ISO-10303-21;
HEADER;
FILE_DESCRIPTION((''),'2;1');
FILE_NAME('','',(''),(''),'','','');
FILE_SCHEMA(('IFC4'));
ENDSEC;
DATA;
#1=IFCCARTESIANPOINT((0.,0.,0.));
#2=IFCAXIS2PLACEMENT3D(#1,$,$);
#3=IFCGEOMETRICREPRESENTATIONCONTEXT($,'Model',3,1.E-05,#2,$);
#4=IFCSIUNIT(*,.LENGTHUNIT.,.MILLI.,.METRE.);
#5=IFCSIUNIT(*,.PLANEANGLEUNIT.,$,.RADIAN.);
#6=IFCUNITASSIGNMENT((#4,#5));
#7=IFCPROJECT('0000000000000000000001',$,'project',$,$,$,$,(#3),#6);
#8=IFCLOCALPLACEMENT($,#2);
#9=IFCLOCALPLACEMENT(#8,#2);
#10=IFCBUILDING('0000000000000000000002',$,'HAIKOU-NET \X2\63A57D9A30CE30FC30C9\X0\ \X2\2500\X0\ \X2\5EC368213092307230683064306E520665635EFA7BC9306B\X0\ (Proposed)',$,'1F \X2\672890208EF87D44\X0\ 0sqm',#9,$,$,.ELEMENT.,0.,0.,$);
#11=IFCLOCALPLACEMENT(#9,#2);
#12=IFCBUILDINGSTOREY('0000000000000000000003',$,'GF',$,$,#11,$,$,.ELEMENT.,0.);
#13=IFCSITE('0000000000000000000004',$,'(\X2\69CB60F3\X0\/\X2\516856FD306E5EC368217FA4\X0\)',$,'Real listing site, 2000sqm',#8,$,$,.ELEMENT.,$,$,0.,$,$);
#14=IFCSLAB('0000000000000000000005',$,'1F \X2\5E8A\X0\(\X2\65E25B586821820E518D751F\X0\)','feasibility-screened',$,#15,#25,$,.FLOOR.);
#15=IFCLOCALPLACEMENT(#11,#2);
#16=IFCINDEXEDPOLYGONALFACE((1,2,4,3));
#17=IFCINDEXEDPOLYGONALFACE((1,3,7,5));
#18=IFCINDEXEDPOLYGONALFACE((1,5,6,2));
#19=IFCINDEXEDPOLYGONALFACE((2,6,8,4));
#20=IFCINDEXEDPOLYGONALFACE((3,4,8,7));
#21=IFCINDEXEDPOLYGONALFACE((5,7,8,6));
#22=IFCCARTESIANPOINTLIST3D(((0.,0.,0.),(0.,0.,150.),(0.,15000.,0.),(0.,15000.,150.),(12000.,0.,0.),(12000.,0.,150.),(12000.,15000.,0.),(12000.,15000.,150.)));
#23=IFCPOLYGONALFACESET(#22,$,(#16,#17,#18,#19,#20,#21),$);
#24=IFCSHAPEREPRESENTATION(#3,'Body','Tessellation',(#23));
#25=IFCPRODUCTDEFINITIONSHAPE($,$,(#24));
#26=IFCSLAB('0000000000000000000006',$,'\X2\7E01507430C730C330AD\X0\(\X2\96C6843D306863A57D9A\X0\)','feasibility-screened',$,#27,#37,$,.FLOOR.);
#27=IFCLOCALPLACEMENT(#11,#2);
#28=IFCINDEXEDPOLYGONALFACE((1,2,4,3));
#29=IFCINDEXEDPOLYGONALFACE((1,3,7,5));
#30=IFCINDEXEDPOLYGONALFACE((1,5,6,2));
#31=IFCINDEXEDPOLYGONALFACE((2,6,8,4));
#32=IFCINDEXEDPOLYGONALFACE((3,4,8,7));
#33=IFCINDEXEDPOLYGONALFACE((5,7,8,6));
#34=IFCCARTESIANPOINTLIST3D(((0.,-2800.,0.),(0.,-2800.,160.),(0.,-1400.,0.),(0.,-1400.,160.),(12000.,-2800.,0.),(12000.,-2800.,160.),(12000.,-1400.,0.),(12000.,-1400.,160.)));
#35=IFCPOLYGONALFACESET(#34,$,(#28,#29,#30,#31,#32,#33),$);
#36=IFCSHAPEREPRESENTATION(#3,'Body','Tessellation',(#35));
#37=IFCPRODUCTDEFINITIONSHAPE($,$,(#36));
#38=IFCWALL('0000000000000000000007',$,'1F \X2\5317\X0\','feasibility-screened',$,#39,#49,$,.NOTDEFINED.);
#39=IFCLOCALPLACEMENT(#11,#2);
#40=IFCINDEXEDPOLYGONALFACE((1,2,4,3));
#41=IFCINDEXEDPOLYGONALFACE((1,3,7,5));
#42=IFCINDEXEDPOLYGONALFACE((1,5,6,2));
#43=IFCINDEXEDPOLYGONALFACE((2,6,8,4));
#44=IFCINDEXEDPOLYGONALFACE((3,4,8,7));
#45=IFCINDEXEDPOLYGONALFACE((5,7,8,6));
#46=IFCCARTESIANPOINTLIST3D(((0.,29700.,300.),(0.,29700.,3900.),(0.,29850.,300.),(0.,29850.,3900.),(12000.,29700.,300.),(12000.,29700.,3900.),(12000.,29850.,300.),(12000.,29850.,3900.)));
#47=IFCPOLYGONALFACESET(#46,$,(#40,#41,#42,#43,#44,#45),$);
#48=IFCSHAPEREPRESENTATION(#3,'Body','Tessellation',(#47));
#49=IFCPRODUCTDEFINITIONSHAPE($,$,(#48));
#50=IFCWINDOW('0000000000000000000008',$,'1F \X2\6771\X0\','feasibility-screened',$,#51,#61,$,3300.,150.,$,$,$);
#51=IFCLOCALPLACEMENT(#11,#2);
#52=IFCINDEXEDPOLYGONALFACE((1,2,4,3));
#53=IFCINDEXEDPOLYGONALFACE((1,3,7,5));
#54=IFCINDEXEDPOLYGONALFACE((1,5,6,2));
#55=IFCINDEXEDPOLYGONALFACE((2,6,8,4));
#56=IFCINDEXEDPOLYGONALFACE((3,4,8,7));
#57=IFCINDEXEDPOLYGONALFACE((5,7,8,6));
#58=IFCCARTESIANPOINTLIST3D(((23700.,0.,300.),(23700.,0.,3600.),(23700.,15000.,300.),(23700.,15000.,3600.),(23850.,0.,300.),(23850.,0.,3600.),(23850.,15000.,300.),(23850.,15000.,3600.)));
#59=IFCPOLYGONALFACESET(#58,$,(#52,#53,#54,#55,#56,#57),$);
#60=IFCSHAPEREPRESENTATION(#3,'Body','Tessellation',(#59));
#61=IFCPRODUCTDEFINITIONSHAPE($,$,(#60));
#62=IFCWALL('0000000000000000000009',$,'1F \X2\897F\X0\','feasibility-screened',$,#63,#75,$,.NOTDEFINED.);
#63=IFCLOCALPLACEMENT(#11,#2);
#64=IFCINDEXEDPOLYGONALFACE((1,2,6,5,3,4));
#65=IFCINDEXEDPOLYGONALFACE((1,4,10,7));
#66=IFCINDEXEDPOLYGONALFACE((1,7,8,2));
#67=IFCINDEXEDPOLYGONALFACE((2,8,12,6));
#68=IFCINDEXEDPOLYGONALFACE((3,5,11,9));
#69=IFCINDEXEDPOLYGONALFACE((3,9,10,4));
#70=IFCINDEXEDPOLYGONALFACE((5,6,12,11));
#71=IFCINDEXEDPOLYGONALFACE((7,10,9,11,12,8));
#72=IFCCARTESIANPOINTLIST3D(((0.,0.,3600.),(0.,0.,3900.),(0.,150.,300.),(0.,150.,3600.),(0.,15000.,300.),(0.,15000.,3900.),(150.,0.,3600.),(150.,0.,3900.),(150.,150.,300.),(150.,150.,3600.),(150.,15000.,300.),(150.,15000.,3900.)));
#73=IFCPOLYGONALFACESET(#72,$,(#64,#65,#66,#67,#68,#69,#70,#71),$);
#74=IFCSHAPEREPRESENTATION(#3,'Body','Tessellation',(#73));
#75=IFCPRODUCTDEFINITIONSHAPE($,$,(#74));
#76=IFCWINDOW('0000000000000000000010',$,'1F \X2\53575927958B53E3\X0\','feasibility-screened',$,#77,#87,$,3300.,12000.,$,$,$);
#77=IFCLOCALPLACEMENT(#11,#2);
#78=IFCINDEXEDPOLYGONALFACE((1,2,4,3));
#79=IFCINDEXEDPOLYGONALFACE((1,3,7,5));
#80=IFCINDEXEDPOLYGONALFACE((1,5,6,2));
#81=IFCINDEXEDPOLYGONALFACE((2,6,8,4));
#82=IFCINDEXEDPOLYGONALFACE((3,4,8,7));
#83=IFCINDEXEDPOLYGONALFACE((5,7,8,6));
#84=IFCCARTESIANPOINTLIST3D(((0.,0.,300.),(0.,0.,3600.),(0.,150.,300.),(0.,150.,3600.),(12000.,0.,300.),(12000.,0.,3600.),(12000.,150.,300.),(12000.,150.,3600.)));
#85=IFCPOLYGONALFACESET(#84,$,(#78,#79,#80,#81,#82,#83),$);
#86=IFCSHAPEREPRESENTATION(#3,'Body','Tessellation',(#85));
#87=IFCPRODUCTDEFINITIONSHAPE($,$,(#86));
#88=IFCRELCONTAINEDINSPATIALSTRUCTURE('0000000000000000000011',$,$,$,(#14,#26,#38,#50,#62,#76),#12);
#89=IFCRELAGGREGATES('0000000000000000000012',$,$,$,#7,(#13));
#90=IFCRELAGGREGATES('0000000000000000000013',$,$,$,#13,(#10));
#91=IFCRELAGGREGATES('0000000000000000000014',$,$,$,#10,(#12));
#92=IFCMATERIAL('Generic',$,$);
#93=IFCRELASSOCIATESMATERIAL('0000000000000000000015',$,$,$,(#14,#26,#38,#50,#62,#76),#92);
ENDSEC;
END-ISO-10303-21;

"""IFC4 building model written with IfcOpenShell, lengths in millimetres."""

from ifc_helpers import new_model, si_unit, frame, frame_2d, origin, place, context, project, spatial, rectangle, extrude, material, element, fill, save


model = new_model("IFC4")

# Units and contexts
model_context = context("Model", 3, precision=1e-05, world=origin())
ifc_project = project(units=[si_unit("LENGTHUNIT", "METRE", prefix="MILLI"), si_unit("PLANEANGLEUNIT", "RADIAN")], contexts=[model_context])

# Site, building, storey
site_placement = place(None, origin())
site = spatial("IfcSite", under=ifc_project, at=site_placement, Name="(構想/全国の廃校群)", ObjectType="Real listing site, 2000sqm", CompositionType="ELEMENT", RefElevation=0.0)
building_placement = place(site_placement, origin())
building = spatial("IfcBuilding", under=site, at=building_placement, Name="HAIKOU-NET 接続ノード ─ 廃校をひとつの分散建築に (Proposed)", ObjectType="1F 木造軸組 0sqm", CompositionType="ELEMENT", ElevationOfRefHeight=0.0, ElevationOfTerrain=0.0)
storey_placement = place(building_placement, origin())
storey = spatial("IfcBuildingStorey", under=building, at=storey_placement, Name="GF", CompositionType="ELEMENT", Elevation=0.0)

# Slabs
ifc_material = material(Name="Generic")
slab_1_placement = place(storey_placement, origin())
element("IfcSlab", 1, at=slab_1_placement, inside=storey, material=ifc_material, Name="1F 床(既存校舎再生)", Description="feasibility-screened", PredefinedType="FLOOR", context=model_context, shape_type="SweptSolid", body=[
    extrude(rectangle(XDim=12000.0, YDim=15000.0, at=frame_2d((6000.0, 7500.0))), origin(), (0.0, 0.0, 1.0), 150.0),
])
slab_2_placement = place(storey_placement, frame((0.0, -1400.0, 0.0)))
element("IfcSlab", 2, at=slab_2_placement, inside=storey, material=ifc_material, Name="縁側デッキ(集落と接続)", Description="feasibility-screened", PredefinedType="FLOOR", context=model_context, shape_type="SweptSolid", body=[
    extrude(rectangle(XDim=12000.0, YDim=1400.0, at=frame_2d((6000.0, 700.0))), frame((0.0, -1400.0, 0.0)), (0.0, 0.0, 1.0), 160.0),
])

# Walls, openings, windows
wall_1_placement = place(storey_placement, frame((0.0, 14850.0, 150.0)))
wall_1 = element("IfcWall", 3, at=wall_1_placement, inside=storey, material=ifc_material, Name="1F 北", Description="feasibility-screened", PredefinedType="NOTDEFINED", context=model_context, shape_type="SweptSolid", body=[
    extrude(rectangle(XDim=12000.0, YDim=150.0, at=frame_2d((6000.0, 75.0))), frame((0.0, 14850.0, 150.0)), (0.0, 0.0, 1.0), 3600.0),
])
opening_1_placement = place(storey_placement, frame((11850.0, 0.0, 150.0)))
opening_1 = element("IfcOpeningElement", 4, at=opening_1_placement, cuts=wall_1, PredefinedType="NOTDEFINED", context=model_context, shape_type="SweptSolid", body=[
    extrude(rectangle(XDim=150.0, YDim=15000.0, at=frame_2d((75.0, 7500.0))), frame((11850.0, 0.0, 150.0)), (0.0, 0.0, 1.0), 3300.0),
])
window_1_placement = place(storey_placement, frame((11850.0, 0.0, 150.0)))
window_1 = element("IfcWindow", 5, at=window_1_placement, inside=storey, material=ifc_material, Name="1F 東", Description="feasibility-screened", OverallHeight=3300.0, OverallWidth=150.0, context=model_context, shape_type="SweptSolid", body=[
    extrude(rectangle(XDim=150.0, YDim=15000.0, at=frame_2d((75.0, 7500.0))), frame((11850.0, 0.0, 150.0)), (0.0, 0.0, 1.0), 3300.0),
])
fill(opening_1, window_1)
wall_2_placement = place(storey_placement, frame((0.0, 0.0, 150.0)))
wall_2 = element("IfcWall", 6, at=wall_2_placement, inside=storey, material=ifc_material, Name="1F 西", Description="feasibility-screened", PredefinedType="NOTDEFINED", context=model_context, shape_type="SweptSolid", body=[
    extrude(rectangle(XDim=150.0, YDim=15000.0, at=frame_2d((75.0, 7500.0))), frame((0.0, 0.0, 150.0)), (0.0, 0.0, 1.0), 3600.0),
])
opening_2_placement = place(storey_placement, frame((0.0, 0.0, 150.0)))
opening_2 = element("IfcOpeningElement", 7, at=opening_2_placement, cuts=wall_2, PredefinedType="NOTDEFINED", context=model_context, shape_type="SweptSolid", body=[
    extrude(rectangle(XDim=12000.0, YDim=150.0, at=frame_2d((6000.0, 75.0))), frame((0.0, 0.0, 150.0)), (0.0, 0.0, 1.0), 3300.0),
])
window_2_placement = place(storey_placement, frame((0.0, 0.0, 150.0)))
window_2 = element("IfcWindow", 8, at=window_2_placement, inside=storey, material=ifc_material, Name="1F 南大開口", Description="feasibility-screened", OverallHeight=3300.0, OverallWidth=12000.0, context=model_context, shape_type="SweptSolid", body=[
    extrude(rectangle(XDim=12000.0, YDim=150.0, at=frame_2d((6000.0, 75.0))), frame((0.0, 0.0, 150.0)), (0.0, 0.0, 1.0), 3300.0),
])
fill(opening_2, window_2)

save(model, "model.ifc")
